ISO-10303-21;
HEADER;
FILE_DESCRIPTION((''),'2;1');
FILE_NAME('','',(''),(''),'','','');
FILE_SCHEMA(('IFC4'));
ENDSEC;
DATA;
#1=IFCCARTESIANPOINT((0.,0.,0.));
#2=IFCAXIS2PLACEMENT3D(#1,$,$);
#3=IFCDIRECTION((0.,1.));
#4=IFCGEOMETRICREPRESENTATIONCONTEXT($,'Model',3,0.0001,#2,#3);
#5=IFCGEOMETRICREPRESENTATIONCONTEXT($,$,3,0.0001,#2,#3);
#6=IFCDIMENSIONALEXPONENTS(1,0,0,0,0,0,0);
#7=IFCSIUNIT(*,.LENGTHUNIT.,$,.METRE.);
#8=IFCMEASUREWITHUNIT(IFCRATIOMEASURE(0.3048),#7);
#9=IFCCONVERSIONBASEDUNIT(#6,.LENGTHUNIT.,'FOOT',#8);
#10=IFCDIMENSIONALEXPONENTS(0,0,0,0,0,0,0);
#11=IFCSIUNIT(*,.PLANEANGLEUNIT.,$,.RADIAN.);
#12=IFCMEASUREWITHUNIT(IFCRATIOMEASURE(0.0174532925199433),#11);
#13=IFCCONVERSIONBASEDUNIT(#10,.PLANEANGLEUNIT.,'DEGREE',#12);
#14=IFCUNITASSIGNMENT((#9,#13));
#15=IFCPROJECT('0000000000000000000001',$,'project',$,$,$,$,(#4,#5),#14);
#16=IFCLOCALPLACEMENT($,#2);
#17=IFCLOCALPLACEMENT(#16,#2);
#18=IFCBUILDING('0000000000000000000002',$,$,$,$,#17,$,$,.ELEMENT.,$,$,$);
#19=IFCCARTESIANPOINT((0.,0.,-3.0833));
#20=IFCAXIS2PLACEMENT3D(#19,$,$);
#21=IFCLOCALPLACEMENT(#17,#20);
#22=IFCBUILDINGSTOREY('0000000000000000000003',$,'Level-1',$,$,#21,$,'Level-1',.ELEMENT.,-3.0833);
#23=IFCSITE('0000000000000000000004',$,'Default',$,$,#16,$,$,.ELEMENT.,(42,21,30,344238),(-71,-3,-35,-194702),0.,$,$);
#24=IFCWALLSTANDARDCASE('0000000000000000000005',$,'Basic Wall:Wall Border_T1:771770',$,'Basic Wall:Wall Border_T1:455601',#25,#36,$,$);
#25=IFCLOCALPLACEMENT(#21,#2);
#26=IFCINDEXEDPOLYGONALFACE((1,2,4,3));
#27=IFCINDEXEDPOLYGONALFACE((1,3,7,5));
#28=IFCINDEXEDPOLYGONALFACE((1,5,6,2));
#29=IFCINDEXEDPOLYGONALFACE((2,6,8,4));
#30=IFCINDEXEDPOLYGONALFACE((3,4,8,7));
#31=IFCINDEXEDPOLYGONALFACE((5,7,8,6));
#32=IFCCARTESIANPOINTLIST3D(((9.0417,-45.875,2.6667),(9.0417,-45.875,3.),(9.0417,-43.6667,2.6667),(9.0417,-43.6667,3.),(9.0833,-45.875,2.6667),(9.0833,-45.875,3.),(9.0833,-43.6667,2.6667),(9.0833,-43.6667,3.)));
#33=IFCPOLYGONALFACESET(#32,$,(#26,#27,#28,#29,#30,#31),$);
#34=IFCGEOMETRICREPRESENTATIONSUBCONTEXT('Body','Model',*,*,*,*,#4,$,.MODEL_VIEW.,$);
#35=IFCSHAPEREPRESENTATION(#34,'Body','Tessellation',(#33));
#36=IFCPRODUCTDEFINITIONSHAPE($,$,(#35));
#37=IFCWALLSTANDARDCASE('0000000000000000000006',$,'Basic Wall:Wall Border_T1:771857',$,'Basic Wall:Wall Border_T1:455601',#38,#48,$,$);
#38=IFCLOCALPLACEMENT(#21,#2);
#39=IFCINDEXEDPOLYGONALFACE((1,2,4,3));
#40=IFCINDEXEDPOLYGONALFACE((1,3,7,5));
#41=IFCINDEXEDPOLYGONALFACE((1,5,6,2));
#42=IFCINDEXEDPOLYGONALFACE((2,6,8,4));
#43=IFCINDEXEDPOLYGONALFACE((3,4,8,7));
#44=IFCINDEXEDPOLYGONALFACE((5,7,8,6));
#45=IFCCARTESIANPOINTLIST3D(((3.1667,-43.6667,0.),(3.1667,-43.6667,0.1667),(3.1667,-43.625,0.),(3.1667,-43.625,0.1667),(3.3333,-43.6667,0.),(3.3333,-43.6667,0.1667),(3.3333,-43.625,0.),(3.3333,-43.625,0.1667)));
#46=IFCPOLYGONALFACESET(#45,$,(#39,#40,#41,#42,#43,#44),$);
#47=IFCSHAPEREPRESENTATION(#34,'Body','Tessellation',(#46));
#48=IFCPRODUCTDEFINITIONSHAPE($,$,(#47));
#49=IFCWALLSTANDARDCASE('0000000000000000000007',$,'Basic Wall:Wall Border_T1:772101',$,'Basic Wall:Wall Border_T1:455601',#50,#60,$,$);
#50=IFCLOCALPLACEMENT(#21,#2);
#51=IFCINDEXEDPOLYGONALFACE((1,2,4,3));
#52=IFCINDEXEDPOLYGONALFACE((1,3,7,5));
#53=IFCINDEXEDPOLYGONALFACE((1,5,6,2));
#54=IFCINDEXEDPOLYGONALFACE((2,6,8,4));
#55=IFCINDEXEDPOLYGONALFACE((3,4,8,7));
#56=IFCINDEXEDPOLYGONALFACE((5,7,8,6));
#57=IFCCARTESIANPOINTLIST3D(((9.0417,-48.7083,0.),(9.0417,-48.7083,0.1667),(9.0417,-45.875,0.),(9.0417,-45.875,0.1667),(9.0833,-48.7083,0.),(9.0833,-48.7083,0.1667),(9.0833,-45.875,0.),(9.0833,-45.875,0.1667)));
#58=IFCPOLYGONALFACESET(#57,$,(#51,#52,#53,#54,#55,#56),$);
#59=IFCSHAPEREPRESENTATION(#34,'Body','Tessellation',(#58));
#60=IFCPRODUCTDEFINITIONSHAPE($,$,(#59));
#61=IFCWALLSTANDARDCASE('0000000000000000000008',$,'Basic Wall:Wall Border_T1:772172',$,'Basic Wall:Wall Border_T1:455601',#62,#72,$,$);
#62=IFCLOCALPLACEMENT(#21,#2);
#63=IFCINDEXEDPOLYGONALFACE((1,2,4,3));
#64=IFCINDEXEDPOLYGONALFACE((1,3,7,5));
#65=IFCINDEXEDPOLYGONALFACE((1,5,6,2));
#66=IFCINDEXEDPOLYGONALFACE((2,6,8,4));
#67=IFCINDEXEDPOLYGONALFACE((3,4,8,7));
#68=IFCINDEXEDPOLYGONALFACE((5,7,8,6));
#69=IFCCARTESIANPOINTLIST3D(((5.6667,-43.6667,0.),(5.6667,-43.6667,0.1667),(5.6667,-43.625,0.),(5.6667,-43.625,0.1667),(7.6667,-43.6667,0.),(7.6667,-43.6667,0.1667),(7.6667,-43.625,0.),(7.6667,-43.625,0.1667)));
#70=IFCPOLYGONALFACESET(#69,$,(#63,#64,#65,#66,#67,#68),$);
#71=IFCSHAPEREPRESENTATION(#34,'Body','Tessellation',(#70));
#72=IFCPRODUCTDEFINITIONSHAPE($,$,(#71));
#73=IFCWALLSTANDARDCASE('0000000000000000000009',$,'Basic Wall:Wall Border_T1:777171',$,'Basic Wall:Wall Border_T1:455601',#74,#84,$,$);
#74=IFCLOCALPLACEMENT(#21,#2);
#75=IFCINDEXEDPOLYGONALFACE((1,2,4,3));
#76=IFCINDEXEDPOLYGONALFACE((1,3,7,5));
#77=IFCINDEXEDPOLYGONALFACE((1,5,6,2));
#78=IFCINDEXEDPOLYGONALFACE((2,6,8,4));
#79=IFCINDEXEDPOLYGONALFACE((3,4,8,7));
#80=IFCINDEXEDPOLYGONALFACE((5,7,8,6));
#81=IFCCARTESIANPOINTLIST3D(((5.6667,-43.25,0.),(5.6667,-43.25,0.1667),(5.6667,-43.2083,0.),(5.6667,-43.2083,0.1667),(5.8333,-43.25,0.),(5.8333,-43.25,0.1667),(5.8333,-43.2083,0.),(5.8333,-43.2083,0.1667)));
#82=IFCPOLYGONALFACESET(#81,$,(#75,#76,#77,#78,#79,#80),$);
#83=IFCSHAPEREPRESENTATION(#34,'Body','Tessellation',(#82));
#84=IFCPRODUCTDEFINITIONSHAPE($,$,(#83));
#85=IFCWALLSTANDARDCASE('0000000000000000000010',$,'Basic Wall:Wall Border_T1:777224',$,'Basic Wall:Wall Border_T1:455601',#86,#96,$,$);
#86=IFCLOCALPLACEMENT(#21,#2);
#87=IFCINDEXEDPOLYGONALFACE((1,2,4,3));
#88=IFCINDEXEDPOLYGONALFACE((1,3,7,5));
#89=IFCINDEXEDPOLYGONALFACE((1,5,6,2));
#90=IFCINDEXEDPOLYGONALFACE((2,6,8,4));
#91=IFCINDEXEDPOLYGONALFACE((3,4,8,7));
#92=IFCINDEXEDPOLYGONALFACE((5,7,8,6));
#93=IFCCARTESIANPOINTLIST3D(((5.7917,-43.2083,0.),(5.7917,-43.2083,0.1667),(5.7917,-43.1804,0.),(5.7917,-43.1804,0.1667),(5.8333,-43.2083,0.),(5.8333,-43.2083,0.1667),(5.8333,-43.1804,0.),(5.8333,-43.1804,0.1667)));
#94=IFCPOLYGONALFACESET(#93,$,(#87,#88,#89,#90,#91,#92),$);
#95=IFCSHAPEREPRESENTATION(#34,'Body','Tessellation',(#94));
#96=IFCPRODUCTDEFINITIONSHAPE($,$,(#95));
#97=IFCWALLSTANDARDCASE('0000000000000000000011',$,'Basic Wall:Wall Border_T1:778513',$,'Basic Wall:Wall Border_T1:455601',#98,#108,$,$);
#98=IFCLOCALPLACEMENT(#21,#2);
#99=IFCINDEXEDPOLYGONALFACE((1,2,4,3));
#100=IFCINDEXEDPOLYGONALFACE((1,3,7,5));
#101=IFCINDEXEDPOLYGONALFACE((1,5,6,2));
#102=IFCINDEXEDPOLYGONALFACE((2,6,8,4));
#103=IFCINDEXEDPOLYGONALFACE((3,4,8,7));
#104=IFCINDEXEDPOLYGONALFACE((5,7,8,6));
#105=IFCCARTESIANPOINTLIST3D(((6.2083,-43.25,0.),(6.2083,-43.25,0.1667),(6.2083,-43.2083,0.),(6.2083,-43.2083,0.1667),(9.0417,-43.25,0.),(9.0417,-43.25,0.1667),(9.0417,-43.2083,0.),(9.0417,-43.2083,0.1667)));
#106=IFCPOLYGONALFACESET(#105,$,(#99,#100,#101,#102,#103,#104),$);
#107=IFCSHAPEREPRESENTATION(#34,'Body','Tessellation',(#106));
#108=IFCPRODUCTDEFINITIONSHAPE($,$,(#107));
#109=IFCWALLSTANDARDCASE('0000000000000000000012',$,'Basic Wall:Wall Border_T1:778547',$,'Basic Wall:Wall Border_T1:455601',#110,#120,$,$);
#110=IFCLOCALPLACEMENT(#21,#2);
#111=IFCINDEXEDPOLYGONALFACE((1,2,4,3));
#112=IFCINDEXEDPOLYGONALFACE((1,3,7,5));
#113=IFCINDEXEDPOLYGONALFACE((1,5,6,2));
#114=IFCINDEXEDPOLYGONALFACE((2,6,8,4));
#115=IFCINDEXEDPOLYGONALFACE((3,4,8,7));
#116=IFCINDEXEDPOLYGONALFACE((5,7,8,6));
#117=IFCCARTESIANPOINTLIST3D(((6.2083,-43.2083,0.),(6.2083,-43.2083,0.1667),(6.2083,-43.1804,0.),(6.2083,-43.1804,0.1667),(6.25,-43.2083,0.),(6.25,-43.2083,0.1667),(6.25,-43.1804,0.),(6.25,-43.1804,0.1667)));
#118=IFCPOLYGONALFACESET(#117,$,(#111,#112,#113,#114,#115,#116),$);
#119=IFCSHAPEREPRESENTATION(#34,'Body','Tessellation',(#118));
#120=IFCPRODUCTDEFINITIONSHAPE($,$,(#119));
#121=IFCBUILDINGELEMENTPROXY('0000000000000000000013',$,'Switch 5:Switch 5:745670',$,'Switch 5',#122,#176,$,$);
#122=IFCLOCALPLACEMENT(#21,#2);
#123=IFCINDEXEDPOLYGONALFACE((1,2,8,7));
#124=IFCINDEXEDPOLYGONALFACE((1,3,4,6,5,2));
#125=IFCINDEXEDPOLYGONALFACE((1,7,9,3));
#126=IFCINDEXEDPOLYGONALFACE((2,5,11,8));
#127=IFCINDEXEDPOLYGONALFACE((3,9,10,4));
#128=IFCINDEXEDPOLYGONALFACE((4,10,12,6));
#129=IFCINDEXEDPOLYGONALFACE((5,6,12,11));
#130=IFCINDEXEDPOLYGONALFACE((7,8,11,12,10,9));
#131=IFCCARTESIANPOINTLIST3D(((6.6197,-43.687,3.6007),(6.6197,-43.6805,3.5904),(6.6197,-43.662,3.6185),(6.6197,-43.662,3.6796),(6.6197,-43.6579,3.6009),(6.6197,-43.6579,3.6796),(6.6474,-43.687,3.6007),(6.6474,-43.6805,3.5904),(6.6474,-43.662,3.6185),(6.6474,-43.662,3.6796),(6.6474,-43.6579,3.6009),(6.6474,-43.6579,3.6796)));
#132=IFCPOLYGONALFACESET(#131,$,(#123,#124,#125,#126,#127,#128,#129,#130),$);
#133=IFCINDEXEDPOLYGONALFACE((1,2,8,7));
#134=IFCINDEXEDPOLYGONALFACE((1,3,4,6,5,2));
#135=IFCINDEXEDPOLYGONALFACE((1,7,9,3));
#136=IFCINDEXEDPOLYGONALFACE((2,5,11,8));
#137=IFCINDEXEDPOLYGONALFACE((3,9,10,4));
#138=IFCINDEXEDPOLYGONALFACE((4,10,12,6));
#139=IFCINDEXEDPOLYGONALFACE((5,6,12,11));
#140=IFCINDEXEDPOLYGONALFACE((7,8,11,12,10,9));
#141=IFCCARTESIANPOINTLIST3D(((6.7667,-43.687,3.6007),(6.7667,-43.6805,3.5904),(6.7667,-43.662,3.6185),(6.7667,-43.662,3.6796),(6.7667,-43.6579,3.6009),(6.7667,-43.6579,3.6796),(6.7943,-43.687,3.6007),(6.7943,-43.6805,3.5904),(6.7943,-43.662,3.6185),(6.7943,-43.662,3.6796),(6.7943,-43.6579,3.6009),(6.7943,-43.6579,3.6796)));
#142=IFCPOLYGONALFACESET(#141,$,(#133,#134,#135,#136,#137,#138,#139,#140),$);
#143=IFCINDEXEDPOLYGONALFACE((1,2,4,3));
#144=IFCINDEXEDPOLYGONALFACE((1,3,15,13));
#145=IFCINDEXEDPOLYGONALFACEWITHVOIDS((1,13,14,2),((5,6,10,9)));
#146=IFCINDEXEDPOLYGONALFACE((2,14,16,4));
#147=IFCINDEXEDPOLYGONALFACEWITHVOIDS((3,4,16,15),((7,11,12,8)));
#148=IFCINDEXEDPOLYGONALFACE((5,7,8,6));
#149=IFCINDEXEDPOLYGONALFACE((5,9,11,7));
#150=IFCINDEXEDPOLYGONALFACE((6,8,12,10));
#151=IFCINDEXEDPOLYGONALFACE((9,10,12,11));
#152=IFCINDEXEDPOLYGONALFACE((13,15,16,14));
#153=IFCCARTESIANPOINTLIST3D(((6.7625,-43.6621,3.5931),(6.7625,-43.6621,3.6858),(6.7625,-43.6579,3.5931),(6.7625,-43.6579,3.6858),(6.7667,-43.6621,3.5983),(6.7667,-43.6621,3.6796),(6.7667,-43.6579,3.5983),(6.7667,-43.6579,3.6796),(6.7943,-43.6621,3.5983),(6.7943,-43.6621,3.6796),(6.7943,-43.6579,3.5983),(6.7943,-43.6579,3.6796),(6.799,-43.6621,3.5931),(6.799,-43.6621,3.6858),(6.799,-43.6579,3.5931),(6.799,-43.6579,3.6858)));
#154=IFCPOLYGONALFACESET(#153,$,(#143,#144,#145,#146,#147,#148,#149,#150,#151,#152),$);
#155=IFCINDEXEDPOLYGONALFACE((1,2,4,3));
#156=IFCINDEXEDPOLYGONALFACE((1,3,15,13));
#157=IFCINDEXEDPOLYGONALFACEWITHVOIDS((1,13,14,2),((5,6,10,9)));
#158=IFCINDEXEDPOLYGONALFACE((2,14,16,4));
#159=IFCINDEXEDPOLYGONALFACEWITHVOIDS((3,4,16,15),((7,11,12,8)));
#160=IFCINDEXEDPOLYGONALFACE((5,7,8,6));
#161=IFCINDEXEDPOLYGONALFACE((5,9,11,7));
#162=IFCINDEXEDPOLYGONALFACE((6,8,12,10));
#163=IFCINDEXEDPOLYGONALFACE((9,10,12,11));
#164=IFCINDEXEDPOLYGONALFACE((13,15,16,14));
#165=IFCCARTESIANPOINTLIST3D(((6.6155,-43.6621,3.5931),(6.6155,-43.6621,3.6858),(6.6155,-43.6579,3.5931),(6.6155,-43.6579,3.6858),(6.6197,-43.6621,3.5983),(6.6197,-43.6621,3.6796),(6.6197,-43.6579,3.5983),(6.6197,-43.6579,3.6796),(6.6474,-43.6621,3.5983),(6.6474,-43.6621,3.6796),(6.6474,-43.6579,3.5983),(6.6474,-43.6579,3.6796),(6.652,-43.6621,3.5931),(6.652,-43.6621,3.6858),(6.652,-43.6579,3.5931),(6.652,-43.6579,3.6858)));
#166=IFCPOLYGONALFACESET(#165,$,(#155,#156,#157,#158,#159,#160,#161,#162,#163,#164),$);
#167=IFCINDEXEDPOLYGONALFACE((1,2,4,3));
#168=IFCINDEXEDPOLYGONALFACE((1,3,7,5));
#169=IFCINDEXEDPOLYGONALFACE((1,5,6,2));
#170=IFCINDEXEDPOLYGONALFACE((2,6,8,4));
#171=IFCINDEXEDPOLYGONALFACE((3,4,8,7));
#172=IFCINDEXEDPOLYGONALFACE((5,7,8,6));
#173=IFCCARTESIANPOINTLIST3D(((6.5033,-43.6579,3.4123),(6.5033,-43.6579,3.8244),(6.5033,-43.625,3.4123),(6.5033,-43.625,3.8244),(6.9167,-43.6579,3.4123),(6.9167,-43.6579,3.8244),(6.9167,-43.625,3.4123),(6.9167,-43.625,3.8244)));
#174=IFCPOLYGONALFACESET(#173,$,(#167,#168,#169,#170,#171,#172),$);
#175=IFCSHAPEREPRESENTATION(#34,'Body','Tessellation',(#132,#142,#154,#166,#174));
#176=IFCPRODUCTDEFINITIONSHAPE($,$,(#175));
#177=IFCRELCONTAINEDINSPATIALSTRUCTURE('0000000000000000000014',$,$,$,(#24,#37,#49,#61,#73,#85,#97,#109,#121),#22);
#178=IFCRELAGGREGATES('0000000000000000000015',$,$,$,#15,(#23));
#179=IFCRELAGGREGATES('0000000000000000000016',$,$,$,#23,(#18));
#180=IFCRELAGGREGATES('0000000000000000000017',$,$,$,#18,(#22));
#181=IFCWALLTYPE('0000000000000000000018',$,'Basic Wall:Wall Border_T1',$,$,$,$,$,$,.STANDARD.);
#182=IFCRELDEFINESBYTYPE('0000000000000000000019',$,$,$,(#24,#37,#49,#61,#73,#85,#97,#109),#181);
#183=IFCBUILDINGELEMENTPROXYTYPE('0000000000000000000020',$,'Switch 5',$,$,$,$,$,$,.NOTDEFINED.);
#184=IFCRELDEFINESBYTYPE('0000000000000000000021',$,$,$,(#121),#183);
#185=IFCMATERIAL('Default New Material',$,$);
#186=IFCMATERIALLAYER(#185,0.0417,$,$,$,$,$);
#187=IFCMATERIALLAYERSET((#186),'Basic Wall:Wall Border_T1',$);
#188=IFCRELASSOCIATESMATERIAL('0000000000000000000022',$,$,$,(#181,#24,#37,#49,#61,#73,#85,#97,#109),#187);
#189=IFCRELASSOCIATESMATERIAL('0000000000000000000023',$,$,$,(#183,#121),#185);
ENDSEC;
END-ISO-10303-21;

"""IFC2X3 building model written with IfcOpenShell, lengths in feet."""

from ifc_helpers import new_model, entity, si_unit, converted_unit, direction, frame, frame_2d, origin, origin_2d_with_axis, place, context, subcontext, project, spatial, polyline, rectangle, outline, extrude, source, transform, mapped, material, layer, layer_set, layer_usage, type_object, type_shapes, element, save


model = new_model("IFC2X3")

# Units and contexts
model_context = context("Model", 3, precision=0.0001, world=origin(), true_north=direction((0.0, 1.0)))
context_of_model = context(None, 3, precision=0.0001, world=origin(), true_north=direction((0.0, 1.0)))
body_context = subcontext(model_context, "Body", "Model", "MODEL_VIEW")
ifc_project = project(units=[converted_unit("LENGTHUNIT", "FOOT", entity("IfcRatioMeasure", 0.3048), si_unit("LENGTHUNIT", "METRE"), dimensions=[1, 0, 0, 0, 0, 0, 0]), converted_unit("PLANEANGLEUNIT", "DEGREE", entity("IfcRatioMeasure", 0.0174532925199433), si_unit("PLANEANGLEUNIT", "RADIAN"), dimensions=[0, 0, 0, 0, 0, 0, 0])], contexts=[model_context, context_of_model])

# Site, building, storey
site_placement = place(None, origin())
site = spatial("IfcSite", under=ifc_project, at=site_placement, Name="Default", CompositionType="ELEMENT", RefLatitude=(42, 21, 30, 344238), RefLongitude=(-71, -3, -35, -194702), RefElevation=0.0)
building_placement = place(site_placement, origin())
building = spatial("IfcBuilding", under=site, at=building_placement, CompositionType="ELEMENT")
storey_placement = place(building_placement, frame((0.0, 0.0, -3.0833)))
storey = spatial("IfcBuildingStorey", under=building, at=storey_placement, Name="Level-1", LongName="Level-1", CompositionType="ELEMENT", Elevation=-3.0833)

# Shared definitions
ifc_material = material(Name="Default New Material")

# Walls
ifc_layer_1 = layer(ifc_material, 0.0417)
ifc_layer_set_1 = layer_set([ifc_layer_1], Name="Basic Wall:Wall Border_T1")
wall_type_1 = type_object("IfcWallType", Name="Basic Wall:Wall Border_T1", PredefinedType="STANDARD", material=ifc_layer_set_1)
ifc_layer_usage_1 = layer_usage(ifc_layer_set_1, "AXIS2", "POSITIVE", -0.0208)
wall_1_placement = place(storey_placement, frame((9.0625, -43.6667, 2.6667), z_axis=(0.0, 0.0, 1.0), x_axis=(0.0, -1.0, 0.0)))
element("IfcWallStandardCase", 1, at=wall_1_placement, inside=storey, type_object=wall_type_1, material=ifc_layer_usage_1, Name="Basic Wall:Wall Border_T1:771770", ObjectType="Basic Wall:Wall Border_T1:455601", context=body_context, shape_type="SweptSolid", body=[
    extrude(rectangle(XDim=2.2083, YDim=0.0417, at=frame_2d((1.1042, 0.0), x_axis=(-1.0, 0.0))), origin(), (0.0, 0.0, 1.0), 0.3333),
])
ifc_layer_usage_2 = layer_usage(ifc_layer_set_1, "AXIS2", "NEGATIVE", 0.0208)
wall_2_placement = place(storey_placement, frame((3.3333, -43.6458, 0.0), z_axis=(0.0, 0.0, 1.0), x_axis=(-1.0, 0.0, 0.0)))
element("IfcWallStandardCase", 2, at=wall_2_placement, inside=storey, type_object=wall_type_1, material=ifc_layer_usage_2, Name="Basic Wall:Wall Border_T1:771857", ObjectType="Basic Wall:Wall Border_T1:455601", context=body_context, shape_type="SweptSolid", body=[
    extrude(rectangle(XDim=0.1667, YDim=0.0417, at=frame_2d((0.0833, 0.0), x_axis=(-1.0, 0.0))), origin(), (0.0, 0.0, 1.0), 0.1667),
])
ifc_layer_usage_3 = layer_usage(ifc_layer_set_1, "AXIS2", "NEGATIVE", 0.0208)
wall_3_placement = place(storey_placement, frame((9.0625, -48.7083, 0.0), z_axis=(0.0, 0.0, 1.0), x_axis=(0.0, 1.0, 0.0)))
element("IfcWallStandardCase", 3, at=wall_3_placement, inside=storey, type_object=wall_type_1, material=ifc_layer_usage_3, Name="Basic Wall:Wall Border_T1:772101", ObjectType="Basic Wall:Wall Border_T1:455601", context=body_context, shape_type="SweptSolid", body=[
    extrude(rectangle(XDim=2.8333, YDim=0.0417, at=frame_2d((1.4167, 0.0), x_axis=(-1.0, 0.0))), origin(), (0.0, 0.0, 1.0), 0.1667),
])
ifc_layer_usage_4 = layer_usage(ifc_layer_set_1, "AXIS2", "POSITIVE", -0.0208)
wall_4_placement = place(storey_placement, frame((5.6667, -43.6458, 0.0)))
element("IfcWallStandardCase", 4, at=wall_4_placement, inside=storey, type_object=wall_type_1, material=ifc_layer_usage_4, Name="Basic Wall:Wall Border_T1:772172", ObjectType="Basic Wall:Wall Border_T1:455601", context=body_context, shape_type="SweptSolid", body=[
    extrude(rectangle(XDim=2.0, YDim=0.0417, at=frame_2d((1.0, 0.0), x_axis=(-1.0, 0.0))), origin(), (0.0, 0.0, 1.0), 0.1667),
])
ifc_layer_usage_5 = layer_usage(ifc_layer_set_1, "AXIS2", "NEGATIVE", 0.0208)
wall_5_placement = place(storey_placement, frame((5.6667, -43.2292, 0.0)))
element("IfcWallStandardCase", 5, at=wall_5_placement, inside=storey, type_object=wall_type_1, material=ifc_layer_usage_5, Name="Basic Wall:Wall Border_T1:777171", ObjectType="Basic Wall:Wall Border_T1:455601", context=body_context, shape_type="SweptSolid", body=[
    extrude(rectangle(XDim=0.1667, YDim=0.0417, at=frame_2d((0.0833, 0.0), x_axis=(-1.0, 0.0))), origin(), (0.0, 0.0, 1.0), 0.1667),
])
ifc_layer_usage_6 = layer_usage(ifc_layer_set_1, "AXIS2", "POSITIVE", -0.0208)
wall_6_placement = place(storey_placement, frame((5.8125, -43.1804, 0.0), z_axis=(0.0, 0.0, 1.0), x_axis=(0.0, -1.0, 0.0)))
element("IfcWallStandardCase", 6, at=wall_6_placement, inside=storey, type_object=wall_type_1, material=ifc_layer_usage_6, Name="Basic Wall:Wall Border_T1:777224", ObjectType="Basic Wall:Wall Border_T1:455601", context=body_context, shape_type="SweptSolid", body=[
    extrude(rectangle(XDim=0.0279, YDim=0.0417, at=frame_2d((0.0139, 0.0), x_axis=(-1.0, 0.0))), origin(), (0.0, 0.0, 1.0), 0.1667),
])
ifc_layer_usage_7 = layer_usage(ifc_layer_set_1, "AXIS2", "POSITIVE", -0.0208)
wall_7_placement = place(storey_placement, frame((9.0417, -43.2292, 0.0), z_axis=(0.0, 0.0, 1.0), x_axis=(-1.0, 0.0, 0.0)))
element("IfcWallStandardCase", 7, at=wall_7_placement, inside=storey, type_object=wall_type_1, material=ifc_layer_usage_7, Name="Basic Wall:Wall Border_T1:778513", ObjectType="Basic Wall:Wall Border_T1:455601", context=body_context, shape_type="SweptSolid", body=[
    extrude(rectangle(XDim=2.8333, YDim=0.0417, at=frame_2d((1.4167, 0.0), x_axis=(-1.0, 0.0))), origin(), (0.0, 0.0, 1.0), 0.1667),
])
ifc_layer_usage_8 = layer_usage(ifc_layer_set_1, "AXIS2", "POSITIVE", -0.0208)
wall_8_placement = place(storey_placement, frame((6.2292, -43.2083, 0.0), z_axis=(0.0, 0.0, 1.0), x_axis=(0.0, 1.0, 0.0)))
element("IfcWallStandardCase", 8, at=wall_8_placement, inside=storey, type_object=wall_type_1, material=ifc_layer_usage_8, Name="Basic Wall:Wall Border_T1:778547", ObjectType="Basic Wall:Wall Border_T1:455601", context=body_context, shape_type="SweptSolid", body=[
    extrude(rectangle(XDim=0.0279, YDim=0.0417, at=frame_2d((0.0139, 0.0), x_axis=(-1.0, 0.0))), origin(), (0.0, 0.0, 1.0), 0.1667),
])

# Building element proxy
building_element_proxy_type_1 = type_object("IfcBuildingElementProxyType", Name="Switch 5", PredefinedType="NOTDEFINED", material=ifc_material)
shared_shape_1 = source(origin(), body_context, "Body", "SweptSolid", [
    extrude(outline(polyline([(-0.0255, -0.0308), (-0.0133, -0.0308), (-0.0115, -0.0002), (0.0405, 0.0322), (0.0383, 0.0356), (-0.0285, -0.006), (-0.0255, -0.0308)])), frame((0.0626, 0.0429, 0.216), z_axis=(1.0, 0.0, 0.0), x_axis=(0.0, 0.528865, 0.848706)), (0.0, 0.0, 1.0), 0.0277),
    extrude(outline(polyline([(-0.0255, -0.0308), (-0.0133, -0.0308), (-0.0115, -0.0002), (0.0405, 0.0322), (0.0383, 0.0356), (-0.0285, -0.006), (-0.0255, -0.0308)])), frame((-0.0843, 0.0429, 0.216), z_axis=(1.0, 0.0, 0.0), x_axis=(0.0, 0.528865, 0.848706)), (0.0, 0.0, 1.0), 0.0277),
    extrude(outline(polyline([(-0.0464, -0.0182), (0.0464, -0.0182), (0.0464, 0.0182), (-0.0464, 0.0182), (-0.0464, -0.0182)]), holes=[polyline([(-0.0402, -0.0141), (-0.0402, 0.0136), (0.0411, 0.0136), (0.0411, -0.0141), (-0.0402, -0.0141)])]), frame((-0.0707, 0.0329, 0.2271), z_axis=(0.0, 1.0, 0.0), x_axis=(0.0, 0.0, -1.0)), (0.0, 0.0, 1.0), 0.0042),
    extrude(outline(polyline([(-0.0464, -0.0182), (0.0464, -0.0182), (0.0464, 0.0182), (-0.0464, 0.0182), (-0.0464, -0.0182)]), holes=[polyline([(-0.0402, -0.0141), (-0.0402, 0.0136), (0.0411, 0.0136), (0.0411, -0.0141), (-0.0402, -0.0141)])]), frame((0.0762, 0.0329, 0.2271), z_axis=(0.0, 1.0, 0.0), x_axis=(0.0, 0.0, -1.0)), (0.0, 0.0, 1.0), 0.0042),
    extrude(rectangle(XDim=0.0329, YDim=0.4134, at=origin_2d_with_axis()), frame((0.0, 0.0164, 0.0), z_axis=(0.0, 0.0, 1.0), x_axis=(0.0, -1.0, 0.0)), (0.0, 0.0, 1.0), 0.4121),
])
type_shapes(building_element_proxy_type_1, [shared_shape_1])
proxy_1_placement = place(storey_placement, frame((6.71, -43.625, 3.4123), z_axis=(0.0, 0.0, 1.0), x_axis=(-1.0, 0.0, 0.0)))
element("IfcBuildingElementProxy", 9, at=proxy_1_placement, inside=storey, type_object=building_element_proxy_type_1, material=ifc_material, Name="Switch 5:Switch 5:745670", ObjectType="Switch 5", context=body_context, shape_type="MappedRepresentation", body=[
    mapped(shared_shape_1, transform((0.0, 0.0, 0.0), scale=1.0)),
])

save(model, "model.ifc")
